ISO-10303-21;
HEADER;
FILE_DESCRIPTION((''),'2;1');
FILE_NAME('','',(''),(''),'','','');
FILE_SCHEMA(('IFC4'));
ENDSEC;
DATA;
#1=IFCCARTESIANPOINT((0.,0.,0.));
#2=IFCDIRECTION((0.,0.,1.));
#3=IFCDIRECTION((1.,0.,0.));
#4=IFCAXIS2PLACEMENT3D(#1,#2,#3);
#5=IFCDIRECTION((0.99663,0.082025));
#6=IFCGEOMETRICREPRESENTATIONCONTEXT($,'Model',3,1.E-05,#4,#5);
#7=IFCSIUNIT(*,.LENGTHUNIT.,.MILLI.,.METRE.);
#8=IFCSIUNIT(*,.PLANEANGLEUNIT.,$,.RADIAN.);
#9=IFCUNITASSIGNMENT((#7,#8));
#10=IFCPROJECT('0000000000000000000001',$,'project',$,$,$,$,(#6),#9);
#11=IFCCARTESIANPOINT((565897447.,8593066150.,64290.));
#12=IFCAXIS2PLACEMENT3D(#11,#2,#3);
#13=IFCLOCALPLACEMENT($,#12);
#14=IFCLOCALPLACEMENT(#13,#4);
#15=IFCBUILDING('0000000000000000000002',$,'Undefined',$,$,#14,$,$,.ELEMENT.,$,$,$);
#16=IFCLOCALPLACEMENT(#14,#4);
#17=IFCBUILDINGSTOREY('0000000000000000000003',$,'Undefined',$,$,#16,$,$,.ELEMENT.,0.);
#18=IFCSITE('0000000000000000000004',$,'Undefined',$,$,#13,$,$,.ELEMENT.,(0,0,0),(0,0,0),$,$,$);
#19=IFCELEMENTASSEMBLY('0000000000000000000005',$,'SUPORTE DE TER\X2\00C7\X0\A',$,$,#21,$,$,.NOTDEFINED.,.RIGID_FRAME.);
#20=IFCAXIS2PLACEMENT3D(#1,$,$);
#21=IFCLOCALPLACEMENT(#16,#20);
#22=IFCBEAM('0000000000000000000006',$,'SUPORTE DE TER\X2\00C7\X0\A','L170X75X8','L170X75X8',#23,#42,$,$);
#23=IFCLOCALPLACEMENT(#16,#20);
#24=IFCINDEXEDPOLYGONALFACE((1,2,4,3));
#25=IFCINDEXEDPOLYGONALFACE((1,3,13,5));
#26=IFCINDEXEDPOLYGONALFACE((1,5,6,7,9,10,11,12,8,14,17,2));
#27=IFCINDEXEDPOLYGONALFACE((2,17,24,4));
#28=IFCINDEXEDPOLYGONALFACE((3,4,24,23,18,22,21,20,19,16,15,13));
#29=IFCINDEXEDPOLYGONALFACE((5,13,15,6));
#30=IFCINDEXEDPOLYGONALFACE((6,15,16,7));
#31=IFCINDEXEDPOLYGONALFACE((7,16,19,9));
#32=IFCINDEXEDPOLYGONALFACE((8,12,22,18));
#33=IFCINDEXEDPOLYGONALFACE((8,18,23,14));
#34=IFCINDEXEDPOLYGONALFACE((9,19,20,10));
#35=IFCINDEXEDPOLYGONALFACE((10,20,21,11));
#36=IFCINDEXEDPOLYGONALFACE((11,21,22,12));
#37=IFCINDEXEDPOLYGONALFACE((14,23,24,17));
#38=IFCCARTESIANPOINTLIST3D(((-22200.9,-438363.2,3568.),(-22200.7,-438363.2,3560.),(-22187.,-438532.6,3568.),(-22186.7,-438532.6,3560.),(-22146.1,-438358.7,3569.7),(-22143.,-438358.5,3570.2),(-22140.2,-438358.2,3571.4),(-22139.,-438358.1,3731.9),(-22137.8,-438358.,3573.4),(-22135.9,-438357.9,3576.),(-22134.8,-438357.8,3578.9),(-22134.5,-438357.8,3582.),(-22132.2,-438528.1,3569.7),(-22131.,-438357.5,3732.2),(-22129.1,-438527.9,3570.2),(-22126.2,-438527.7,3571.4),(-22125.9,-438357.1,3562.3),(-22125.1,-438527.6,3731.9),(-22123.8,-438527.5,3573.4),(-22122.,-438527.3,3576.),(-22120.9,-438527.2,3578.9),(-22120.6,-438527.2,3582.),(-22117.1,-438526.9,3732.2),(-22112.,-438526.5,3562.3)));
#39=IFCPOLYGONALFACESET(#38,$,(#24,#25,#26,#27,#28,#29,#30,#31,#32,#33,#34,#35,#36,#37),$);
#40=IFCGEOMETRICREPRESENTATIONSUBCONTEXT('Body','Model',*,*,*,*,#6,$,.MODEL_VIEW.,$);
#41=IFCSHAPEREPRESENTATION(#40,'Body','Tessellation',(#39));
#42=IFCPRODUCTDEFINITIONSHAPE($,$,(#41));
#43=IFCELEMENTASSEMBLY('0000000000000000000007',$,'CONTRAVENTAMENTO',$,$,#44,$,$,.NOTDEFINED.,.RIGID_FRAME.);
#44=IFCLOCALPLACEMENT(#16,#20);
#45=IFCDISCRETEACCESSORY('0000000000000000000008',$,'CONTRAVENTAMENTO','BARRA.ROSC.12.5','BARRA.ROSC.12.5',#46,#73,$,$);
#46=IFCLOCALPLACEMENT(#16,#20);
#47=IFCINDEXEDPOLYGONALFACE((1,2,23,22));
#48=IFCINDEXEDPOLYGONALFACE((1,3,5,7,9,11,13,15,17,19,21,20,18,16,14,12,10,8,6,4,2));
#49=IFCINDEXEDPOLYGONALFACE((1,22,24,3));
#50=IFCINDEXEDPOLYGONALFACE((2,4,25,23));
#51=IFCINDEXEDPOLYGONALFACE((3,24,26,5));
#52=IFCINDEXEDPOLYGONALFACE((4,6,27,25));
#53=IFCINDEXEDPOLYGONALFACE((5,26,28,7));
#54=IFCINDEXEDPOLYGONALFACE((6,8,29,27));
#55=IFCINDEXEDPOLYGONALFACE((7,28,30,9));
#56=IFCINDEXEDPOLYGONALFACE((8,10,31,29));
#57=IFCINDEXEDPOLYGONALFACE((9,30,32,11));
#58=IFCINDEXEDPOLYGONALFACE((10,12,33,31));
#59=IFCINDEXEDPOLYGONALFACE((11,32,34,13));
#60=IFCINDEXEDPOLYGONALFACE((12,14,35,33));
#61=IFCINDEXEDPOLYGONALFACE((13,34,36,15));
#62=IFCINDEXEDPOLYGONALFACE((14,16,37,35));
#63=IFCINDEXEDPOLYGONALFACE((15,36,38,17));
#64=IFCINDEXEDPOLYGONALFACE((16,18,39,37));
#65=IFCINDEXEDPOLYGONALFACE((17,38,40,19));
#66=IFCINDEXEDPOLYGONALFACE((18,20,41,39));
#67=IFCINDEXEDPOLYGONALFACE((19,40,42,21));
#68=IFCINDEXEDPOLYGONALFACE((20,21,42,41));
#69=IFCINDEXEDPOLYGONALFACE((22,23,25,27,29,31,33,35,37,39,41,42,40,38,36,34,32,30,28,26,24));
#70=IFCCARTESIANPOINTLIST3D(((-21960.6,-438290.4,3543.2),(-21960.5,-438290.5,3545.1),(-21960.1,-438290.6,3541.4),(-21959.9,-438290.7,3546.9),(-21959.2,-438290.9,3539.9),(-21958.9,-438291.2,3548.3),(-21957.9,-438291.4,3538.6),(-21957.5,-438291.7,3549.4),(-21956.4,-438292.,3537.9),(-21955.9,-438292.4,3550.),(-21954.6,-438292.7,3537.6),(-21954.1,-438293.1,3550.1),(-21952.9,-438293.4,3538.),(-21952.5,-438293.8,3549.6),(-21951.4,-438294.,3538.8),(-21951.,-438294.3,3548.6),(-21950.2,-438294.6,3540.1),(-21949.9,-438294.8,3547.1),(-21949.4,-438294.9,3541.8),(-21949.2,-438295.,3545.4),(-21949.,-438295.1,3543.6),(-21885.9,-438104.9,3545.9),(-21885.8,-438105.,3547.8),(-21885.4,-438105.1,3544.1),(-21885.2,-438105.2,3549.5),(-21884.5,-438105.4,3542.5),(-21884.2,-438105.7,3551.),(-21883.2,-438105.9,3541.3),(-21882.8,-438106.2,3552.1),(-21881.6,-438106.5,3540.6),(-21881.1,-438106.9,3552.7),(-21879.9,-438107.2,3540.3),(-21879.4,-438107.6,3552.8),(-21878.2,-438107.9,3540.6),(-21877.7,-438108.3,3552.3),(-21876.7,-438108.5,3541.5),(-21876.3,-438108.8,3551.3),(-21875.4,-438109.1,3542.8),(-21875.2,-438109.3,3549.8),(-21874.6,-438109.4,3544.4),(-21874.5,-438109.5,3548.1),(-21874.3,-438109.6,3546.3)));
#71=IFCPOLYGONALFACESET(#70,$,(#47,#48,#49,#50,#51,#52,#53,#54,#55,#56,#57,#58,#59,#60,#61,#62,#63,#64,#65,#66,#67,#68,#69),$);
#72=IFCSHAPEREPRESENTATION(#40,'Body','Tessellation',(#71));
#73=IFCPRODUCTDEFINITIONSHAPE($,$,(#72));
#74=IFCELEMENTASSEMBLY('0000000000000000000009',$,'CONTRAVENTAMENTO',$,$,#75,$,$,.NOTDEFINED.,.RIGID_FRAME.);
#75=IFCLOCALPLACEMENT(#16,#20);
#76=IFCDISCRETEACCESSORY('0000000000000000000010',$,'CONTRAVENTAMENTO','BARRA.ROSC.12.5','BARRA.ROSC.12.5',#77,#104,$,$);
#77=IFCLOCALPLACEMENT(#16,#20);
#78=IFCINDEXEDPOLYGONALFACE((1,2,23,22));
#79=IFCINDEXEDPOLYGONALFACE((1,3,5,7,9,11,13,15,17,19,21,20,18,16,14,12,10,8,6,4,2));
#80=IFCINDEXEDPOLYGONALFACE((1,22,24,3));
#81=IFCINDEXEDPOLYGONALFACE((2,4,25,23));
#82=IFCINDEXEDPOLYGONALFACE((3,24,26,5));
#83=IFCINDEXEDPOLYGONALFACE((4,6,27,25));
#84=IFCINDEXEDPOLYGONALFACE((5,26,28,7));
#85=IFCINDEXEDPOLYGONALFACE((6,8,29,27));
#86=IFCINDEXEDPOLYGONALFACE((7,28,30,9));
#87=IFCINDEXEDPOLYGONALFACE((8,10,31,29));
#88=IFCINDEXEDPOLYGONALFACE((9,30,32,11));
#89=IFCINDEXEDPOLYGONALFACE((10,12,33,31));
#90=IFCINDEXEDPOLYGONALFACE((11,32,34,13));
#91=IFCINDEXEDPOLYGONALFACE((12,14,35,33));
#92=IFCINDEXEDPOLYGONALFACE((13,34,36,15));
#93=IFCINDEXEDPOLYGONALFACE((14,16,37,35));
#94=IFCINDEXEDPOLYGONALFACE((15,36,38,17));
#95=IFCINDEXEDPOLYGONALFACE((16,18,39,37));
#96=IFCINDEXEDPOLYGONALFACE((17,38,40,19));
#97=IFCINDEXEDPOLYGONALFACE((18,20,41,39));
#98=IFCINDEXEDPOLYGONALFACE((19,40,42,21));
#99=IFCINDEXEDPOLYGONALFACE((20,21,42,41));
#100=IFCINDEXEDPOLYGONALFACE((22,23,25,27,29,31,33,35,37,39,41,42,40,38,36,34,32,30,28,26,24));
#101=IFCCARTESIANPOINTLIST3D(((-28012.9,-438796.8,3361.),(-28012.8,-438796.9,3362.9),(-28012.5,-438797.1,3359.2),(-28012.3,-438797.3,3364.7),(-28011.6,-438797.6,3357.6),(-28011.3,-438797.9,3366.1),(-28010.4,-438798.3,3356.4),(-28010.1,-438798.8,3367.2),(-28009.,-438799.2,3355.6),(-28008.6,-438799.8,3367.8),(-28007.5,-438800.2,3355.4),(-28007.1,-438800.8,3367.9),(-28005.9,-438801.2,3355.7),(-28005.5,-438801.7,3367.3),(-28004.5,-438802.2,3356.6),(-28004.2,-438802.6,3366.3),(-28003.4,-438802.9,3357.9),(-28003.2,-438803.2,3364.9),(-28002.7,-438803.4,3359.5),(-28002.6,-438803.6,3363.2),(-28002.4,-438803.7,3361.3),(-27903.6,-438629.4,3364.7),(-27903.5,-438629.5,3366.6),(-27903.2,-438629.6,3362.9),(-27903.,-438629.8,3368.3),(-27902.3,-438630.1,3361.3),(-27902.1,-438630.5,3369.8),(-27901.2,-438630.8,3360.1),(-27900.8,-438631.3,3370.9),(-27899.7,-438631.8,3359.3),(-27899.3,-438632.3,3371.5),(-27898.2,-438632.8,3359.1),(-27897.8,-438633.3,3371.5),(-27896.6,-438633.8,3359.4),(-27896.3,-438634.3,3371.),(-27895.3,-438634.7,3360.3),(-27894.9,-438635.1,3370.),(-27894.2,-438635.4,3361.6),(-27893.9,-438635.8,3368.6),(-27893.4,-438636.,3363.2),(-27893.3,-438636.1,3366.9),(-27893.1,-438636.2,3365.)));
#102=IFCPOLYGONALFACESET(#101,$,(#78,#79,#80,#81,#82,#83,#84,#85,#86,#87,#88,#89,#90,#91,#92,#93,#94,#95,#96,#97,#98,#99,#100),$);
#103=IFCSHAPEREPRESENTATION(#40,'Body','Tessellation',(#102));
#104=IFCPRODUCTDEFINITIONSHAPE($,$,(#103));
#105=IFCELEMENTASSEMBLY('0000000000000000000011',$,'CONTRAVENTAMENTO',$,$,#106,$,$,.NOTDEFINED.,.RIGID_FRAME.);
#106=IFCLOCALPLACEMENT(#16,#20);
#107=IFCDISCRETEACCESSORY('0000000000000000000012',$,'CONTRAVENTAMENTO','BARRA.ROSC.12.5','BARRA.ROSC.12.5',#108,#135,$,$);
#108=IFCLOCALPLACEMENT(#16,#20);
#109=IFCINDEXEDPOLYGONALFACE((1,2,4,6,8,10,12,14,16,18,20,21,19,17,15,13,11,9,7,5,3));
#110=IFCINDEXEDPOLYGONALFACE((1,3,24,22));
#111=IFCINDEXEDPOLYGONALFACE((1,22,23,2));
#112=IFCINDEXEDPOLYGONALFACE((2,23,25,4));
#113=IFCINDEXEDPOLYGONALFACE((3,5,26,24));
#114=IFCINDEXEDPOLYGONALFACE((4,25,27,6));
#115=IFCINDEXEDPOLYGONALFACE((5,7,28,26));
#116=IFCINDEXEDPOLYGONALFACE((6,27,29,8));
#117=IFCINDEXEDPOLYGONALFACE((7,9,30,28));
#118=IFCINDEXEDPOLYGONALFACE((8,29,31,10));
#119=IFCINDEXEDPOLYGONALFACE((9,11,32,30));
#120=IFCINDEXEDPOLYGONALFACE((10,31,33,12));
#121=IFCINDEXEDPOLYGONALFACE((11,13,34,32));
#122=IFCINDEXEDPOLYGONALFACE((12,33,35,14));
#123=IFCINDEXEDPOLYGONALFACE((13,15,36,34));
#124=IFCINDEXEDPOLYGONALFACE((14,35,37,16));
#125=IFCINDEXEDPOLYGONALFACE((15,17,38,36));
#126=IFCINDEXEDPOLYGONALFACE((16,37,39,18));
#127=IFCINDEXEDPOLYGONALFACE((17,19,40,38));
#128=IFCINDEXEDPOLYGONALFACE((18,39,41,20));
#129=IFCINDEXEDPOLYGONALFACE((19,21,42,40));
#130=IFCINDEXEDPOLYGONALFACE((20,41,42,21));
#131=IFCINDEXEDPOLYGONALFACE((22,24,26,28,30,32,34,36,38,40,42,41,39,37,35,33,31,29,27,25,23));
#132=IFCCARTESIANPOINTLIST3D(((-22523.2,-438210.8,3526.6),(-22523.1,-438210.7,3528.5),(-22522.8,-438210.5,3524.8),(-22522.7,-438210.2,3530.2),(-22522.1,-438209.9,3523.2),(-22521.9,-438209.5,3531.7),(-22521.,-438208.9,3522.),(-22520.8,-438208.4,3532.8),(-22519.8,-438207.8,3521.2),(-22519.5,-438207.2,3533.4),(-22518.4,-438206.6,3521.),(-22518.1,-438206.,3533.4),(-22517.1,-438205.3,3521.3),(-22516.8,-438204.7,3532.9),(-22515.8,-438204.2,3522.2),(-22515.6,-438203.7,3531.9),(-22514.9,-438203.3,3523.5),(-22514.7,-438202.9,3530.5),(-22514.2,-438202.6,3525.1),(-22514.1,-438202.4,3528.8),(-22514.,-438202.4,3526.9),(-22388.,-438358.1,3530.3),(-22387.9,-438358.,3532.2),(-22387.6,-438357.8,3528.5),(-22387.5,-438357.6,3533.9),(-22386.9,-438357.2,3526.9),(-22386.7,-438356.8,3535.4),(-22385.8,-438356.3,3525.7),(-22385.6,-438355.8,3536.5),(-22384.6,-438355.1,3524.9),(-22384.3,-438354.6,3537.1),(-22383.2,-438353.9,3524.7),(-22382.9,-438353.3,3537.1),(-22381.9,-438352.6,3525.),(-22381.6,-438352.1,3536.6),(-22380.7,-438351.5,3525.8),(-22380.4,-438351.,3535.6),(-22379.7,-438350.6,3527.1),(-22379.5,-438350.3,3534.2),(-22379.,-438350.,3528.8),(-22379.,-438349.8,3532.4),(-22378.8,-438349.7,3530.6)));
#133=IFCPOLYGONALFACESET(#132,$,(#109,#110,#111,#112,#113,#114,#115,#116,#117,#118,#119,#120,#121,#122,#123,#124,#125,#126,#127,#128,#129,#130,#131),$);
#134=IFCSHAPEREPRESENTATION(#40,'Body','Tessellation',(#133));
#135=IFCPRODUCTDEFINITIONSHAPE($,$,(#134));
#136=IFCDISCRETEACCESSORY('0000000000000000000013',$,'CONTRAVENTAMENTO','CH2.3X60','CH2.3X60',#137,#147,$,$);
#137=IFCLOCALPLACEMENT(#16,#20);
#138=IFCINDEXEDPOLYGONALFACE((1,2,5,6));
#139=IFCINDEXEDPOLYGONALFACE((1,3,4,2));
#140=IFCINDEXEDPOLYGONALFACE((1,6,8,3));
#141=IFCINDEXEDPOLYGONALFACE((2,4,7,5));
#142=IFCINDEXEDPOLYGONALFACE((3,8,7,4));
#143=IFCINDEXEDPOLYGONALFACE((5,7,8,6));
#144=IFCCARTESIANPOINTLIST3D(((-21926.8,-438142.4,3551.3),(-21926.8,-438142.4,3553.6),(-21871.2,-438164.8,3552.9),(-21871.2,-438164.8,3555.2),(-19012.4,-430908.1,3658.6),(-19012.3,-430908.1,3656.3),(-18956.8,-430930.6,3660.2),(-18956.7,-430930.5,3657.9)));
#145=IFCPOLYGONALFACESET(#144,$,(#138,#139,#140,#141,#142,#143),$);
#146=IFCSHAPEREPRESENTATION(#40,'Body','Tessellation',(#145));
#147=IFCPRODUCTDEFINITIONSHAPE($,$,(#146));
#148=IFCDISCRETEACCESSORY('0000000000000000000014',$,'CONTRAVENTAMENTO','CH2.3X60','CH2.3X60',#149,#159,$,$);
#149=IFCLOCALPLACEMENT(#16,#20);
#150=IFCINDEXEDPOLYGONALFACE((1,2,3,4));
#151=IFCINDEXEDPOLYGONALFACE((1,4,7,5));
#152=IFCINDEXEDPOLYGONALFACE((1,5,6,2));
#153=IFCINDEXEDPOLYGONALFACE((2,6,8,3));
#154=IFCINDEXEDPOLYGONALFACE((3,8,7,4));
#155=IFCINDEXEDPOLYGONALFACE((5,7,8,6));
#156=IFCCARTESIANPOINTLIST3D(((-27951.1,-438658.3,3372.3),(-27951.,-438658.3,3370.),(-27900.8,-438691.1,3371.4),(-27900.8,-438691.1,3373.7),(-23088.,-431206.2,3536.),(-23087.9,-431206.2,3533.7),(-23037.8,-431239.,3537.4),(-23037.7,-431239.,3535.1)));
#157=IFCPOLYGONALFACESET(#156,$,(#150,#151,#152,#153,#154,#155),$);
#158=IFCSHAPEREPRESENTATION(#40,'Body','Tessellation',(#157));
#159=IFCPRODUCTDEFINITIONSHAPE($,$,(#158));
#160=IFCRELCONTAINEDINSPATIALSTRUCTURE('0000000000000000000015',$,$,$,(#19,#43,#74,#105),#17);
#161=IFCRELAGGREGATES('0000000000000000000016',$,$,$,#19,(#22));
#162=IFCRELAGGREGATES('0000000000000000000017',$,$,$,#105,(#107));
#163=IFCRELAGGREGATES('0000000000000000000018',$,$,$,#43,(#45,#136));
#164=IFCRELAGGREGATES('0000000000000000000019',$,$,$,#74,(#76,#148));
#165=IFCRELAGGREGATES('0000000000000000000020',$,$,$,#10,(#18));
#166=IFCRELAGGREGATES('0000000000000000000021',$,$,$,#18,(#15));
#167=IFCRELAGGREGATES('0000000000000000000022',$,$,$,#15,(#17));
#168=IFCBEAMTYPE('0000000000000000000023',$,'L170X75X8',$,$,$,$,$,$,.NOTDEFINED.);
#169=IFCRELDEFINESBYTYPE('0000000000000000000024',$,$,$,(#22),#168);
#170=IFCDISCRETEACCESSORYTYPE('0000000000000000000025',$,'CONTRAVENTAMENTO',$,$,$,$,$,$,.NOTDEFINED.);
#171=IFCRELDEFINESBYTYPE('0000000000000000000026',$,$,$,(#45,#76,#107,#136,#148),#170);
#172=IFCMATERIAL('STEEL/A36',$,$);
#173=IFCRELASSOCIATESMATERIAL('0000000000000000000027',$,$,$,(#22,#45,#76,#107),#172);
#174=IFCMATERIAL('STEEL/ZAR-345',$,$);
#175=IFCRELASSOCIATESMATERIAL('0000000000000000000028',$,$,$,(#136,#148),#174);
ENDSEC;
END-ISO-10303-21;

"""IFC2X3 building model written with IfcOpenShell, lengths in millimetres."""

from ifc_helpers import new_model, si_unit, direction, frame, origin_with_axes, origin_2d_with_axis, place, context, subcontext, project, spatial, polyline, circle, l_section, outline, extrude, material, type_object, element, aggregate, save


model = new_model("IFC2X3")

# Units and contexts
model_context = context("Model", 3, precision=1e-05, world=origin_with_axes(), true_north=direction((0.99663, 0.082025)))
body_context = subcontext(model_context, "Body", "Model", "MODEL_VIEW")
ifc_project = project(units=[si_unit("LENGTHUNIT", "METRE", prefix="MILLI"), si_unit("PLANEANGLEUNIT", "RADIAN")], contexts=[model_context])

# Site, building, storey
site_placement = place(None, frame((565897447.0, 8593066150.0, 64290.0), z_axis=(0.0, 0.0, 1.0), x_axis=(1.0, 0.0, 0.0)))
site = spatial("IfcSite", under=ifc_project, at=site_placement, Name="Undefined", CompositionType="ELEMENT", RefLatitude=(0, 0, 0), RefLongitude=(0, 0, 0))
building_placement = place(site_placement, origin_with_axes())
building = spatial("IfcBuilding", under=site, at=building_placement, Name="Undefined", CompositionType="ELEMENT")
storey_placement = place(building_placement, origin_with_axes())
storey = spatial("IfcBuildingStorey", under=building, at=storey_placement, Name="Undefined", CompositionType="ELEMENT", Elevation=0.0)

# Element assembly, beam
ifc_material_1 = material(Name="STEEL/A36")
beam_type_1 = type_object("IfcBeamType", Name="L170X75X8", PredefinedType="NOTDEFINED")
assembly_1_placement = place(storey_placement, origin_with_axes())
assembly_1 = element("IfcElementAssembly", 1, at=assembly_1_placement, inside=storey, Name="SUPORTE DE TERÇA", AssemblyPlace="NOTDEFINED", PredefinedType="RIGID_FRAME")
beam_1_placement = place(assembly_1_placement, frame((-22165.8, -438360.3, 3646.1), z_axis=(-0.029885, -0.00246, 0.99955), x_axis=(0.082025, -0.99663, 0.0)))
beam_1 = element("IfcBeam", 2, at=beam_1_placement, type_object=beam_type_1, material=ifc_material_1, Name="SUPORTE DE TERÇA", Description="L170X75X8", ObjectType="L170X75X8", context=body_context, shape_type="SweptSolid", body=[
    extrude(l_section(Depth=170.0, Width=75.0, Thickness=8.0, FilletRadius=12.0, at=origin_2d_with_axis()), frame((170.0, 0.0, 0.0), z_axis=(-1.0, 0.0, 0.0), x_axis=(0.0, -1.0, 0.0)), (0.0, 0.0, 1.0), 170.0),
])
aggregate(assembly_1, [beam_1])

# Element assemblies, discrete accessories
assembly_2_placement = place(storey_placement, origin_with_axes())
assembly_2 = element("IfcElementAssembly", 3, at=assembly_2_placement, inside=storey, Name="CONTRAVENTAMENTO", AssemblyPlace="NOTDEFINED", PredefinedType="RIGID_FRAME")
discrete_accessory_type_1 = type_object("IfcDiscreteAccessoryType", Name="CONTRAVENTAMENTO")
discrete_accessory_1_placement = place(assembly_2_placement, frame((-21954.8, -438292.7, 3543.9), z_axis=(0.92709, -0.373879, 0.026799), x_axis=(0.373645, 0.927474, 0.013454)))
discrete_accessory_1 = element("IfcDiscreteAccessory", 4, at=discrete_accessory_1_placement, type_object=discrete_accessory_type_1, material=ifc_material_1, Name="CONTRAVENTAMENTO", Description="BARRA.ROSC.12.5", ObjectType="BARRA.ROSC.12.5", context=body_context, shape_type="SweptSolid", body=[
    extrude(circle(Radius=6.2, at=origin_2d_with_axis()), frame((200.0, 0.0, 0.0), z_axis=(-1.0, 0.0, 0.0), x_axis=(0.0, -1.0, 0.0)), (0.0, 0.0, 1.0), 200.0),
])
assembly_3_placement = place(storey_placement, origin_with_axes())
assembly_3 = element("IfcElementAssembly", 5, at=assembly_3_placement, inside=storey, Name="CONTRAVENTAMENTO", AssemblyPlace="NOTDEFINED", PredefinedType="RIGID_FRAME")
discrete_accessory_2_placement = place(assembly_3_placement, frame((-28007.6, -438800.2, 3361.7), z_axis=(0.836984, -0.546715, 0.02368), x_axis=(0.546411, 0.837315, 0.018398)))
discrete_accessory_2 = element("IfcDiscreteAccessory", 6, at=discrete_accessory_2_placement, type_object=discrete_accessory_type_1, material=ifc_material_1, Name="CONTRAVENTAMENTO", Description="BARRA.ROSC.12.5", ObjectType="BARRA.ROSC.12.5", context=body_context, shape_type="SweptSolid", body=[
    extrude(circle(Radius=6.2, at=origin_2d_with_axis()), frame((200.0, 0.0, 0.0), z_axis=(-1.0, 0.0, 0.0), x_axis=(0.0, -1.0, 0.0)), (0.0, 0.0, 1.0), 200.0),
])
assembly_4_placement = place(storey_placement, origin_with_axes())
assembly_4 = element("IfcElementAssembly", 7, at=assembly_4_placement, inside=storey, Name="CONTRAVENTAMENTO", AssemblyPlace="NOTDEFINED", PredefinedType="RIGID_FRAME")
discrete_accessory_3_placement = place(assembly_4_placement, frame((-22383.4, -438353.9, 3530.9), z_axis=(0.736334, 0.676203, 0.02368), x_axis=(-0.675958, 0.736711, -0.018398)))
discrete_accessory_3 = element("IfcDiscreteAccessory", 8, at=discrete_accessory_3_placement, type_object=discrete_accessory_type_1, material=ifc_material_1, Name="CONTRAVENTAMENTO", Description="BARRA.ROSC.12.5", ObjectType="BARRA.ROSC.12.5", context=body_context, shape_type="SweptSolid", body=[
    extrude(circle(Radius=6.2, at=origin_2d_with_axis()), frame((200.0, 0.0, 0.0), z_axis=(-1.0, 0.0, 0.0), x_axis=(0.0, -1.0, 0.0)), (0.0, 0.0, 1.0), 200.0),
])
aggregate(assembly_4, [discrete_accessory_3])

# Discrete accessories
ifc_material_2 = material(Name="STEEL/ZAR-345")
discrete_accessory_4_placement = place(assembly_2_placement, frame((-21899.0, -438153.6, 3553.3), z_axis=(0.029885, 0.00246, -0.99955), x_axis=(0.373645, 0.927474, 0.013454)))
discrete_accessory_4 = element("IfcDiscreteAccessory", 9, at=discrete_accessory_4_placement, type_object=discrete_accessory_type_1, material=ifc_material_2, Name="CONTRAVENTAMENTO", Description="CH2.3X60", ObjectType="CH2.3X60", context=body_context, shape_type="SweptSolid", body=[
    extrude(outline(polyline([(7800.0, -30.0), (0.0, -30.0), (0.0, 30.0), (7800.0, 30.0), (7800.0, -30.0)])), frame((0.0, 0.0, -1.1), z_axis=(0.0, 0.0, 1.0), x_axis=(1.0, 0.0, 0.0)), (0.0, 0.0, 1.0), 2.3),
])
aggregate(assembly_2, [discrete_accessory_1, discrete_accessory_4])
discrete_accessory_5_placement = place(assembly_3_placement, frame((-27925.9, -438674.7, 3371.8), z_axis=(0.029885, 0.00246, -0.99955), x_axis=(0.546411, 0.837315, 0.018398)))
discrete_accessory_5 = element("IfcDiscreteAccessory", 10, at=discrete_accessory_5_placement, type_object=discrete_accessory_type_1, material=ifc_material_2, Name="CONTRAVENTAMENTO", Description="CH2.3X60", ObjectType="CH2.3X60", context=body_context, shape_type="SweptSolid", body=[
    extrude(outline(polyline([(8900.0, -30.0), (0.0, -30.0), (0.0, 30.0), (8900.0, 30.0), (8900.0, -30.0)])), frame((0.0, 0.0, -1.1), z_axis=(0.0, 0.0, 1.0), x_axis=(1.0, 0.0, 0.0)), (0.0, 0.0, 1.0), 2.3),
])
aggregate(assembly_3, [discrete_accessory_2, discrete_accessory_5])

save(model, "model.ifc")
